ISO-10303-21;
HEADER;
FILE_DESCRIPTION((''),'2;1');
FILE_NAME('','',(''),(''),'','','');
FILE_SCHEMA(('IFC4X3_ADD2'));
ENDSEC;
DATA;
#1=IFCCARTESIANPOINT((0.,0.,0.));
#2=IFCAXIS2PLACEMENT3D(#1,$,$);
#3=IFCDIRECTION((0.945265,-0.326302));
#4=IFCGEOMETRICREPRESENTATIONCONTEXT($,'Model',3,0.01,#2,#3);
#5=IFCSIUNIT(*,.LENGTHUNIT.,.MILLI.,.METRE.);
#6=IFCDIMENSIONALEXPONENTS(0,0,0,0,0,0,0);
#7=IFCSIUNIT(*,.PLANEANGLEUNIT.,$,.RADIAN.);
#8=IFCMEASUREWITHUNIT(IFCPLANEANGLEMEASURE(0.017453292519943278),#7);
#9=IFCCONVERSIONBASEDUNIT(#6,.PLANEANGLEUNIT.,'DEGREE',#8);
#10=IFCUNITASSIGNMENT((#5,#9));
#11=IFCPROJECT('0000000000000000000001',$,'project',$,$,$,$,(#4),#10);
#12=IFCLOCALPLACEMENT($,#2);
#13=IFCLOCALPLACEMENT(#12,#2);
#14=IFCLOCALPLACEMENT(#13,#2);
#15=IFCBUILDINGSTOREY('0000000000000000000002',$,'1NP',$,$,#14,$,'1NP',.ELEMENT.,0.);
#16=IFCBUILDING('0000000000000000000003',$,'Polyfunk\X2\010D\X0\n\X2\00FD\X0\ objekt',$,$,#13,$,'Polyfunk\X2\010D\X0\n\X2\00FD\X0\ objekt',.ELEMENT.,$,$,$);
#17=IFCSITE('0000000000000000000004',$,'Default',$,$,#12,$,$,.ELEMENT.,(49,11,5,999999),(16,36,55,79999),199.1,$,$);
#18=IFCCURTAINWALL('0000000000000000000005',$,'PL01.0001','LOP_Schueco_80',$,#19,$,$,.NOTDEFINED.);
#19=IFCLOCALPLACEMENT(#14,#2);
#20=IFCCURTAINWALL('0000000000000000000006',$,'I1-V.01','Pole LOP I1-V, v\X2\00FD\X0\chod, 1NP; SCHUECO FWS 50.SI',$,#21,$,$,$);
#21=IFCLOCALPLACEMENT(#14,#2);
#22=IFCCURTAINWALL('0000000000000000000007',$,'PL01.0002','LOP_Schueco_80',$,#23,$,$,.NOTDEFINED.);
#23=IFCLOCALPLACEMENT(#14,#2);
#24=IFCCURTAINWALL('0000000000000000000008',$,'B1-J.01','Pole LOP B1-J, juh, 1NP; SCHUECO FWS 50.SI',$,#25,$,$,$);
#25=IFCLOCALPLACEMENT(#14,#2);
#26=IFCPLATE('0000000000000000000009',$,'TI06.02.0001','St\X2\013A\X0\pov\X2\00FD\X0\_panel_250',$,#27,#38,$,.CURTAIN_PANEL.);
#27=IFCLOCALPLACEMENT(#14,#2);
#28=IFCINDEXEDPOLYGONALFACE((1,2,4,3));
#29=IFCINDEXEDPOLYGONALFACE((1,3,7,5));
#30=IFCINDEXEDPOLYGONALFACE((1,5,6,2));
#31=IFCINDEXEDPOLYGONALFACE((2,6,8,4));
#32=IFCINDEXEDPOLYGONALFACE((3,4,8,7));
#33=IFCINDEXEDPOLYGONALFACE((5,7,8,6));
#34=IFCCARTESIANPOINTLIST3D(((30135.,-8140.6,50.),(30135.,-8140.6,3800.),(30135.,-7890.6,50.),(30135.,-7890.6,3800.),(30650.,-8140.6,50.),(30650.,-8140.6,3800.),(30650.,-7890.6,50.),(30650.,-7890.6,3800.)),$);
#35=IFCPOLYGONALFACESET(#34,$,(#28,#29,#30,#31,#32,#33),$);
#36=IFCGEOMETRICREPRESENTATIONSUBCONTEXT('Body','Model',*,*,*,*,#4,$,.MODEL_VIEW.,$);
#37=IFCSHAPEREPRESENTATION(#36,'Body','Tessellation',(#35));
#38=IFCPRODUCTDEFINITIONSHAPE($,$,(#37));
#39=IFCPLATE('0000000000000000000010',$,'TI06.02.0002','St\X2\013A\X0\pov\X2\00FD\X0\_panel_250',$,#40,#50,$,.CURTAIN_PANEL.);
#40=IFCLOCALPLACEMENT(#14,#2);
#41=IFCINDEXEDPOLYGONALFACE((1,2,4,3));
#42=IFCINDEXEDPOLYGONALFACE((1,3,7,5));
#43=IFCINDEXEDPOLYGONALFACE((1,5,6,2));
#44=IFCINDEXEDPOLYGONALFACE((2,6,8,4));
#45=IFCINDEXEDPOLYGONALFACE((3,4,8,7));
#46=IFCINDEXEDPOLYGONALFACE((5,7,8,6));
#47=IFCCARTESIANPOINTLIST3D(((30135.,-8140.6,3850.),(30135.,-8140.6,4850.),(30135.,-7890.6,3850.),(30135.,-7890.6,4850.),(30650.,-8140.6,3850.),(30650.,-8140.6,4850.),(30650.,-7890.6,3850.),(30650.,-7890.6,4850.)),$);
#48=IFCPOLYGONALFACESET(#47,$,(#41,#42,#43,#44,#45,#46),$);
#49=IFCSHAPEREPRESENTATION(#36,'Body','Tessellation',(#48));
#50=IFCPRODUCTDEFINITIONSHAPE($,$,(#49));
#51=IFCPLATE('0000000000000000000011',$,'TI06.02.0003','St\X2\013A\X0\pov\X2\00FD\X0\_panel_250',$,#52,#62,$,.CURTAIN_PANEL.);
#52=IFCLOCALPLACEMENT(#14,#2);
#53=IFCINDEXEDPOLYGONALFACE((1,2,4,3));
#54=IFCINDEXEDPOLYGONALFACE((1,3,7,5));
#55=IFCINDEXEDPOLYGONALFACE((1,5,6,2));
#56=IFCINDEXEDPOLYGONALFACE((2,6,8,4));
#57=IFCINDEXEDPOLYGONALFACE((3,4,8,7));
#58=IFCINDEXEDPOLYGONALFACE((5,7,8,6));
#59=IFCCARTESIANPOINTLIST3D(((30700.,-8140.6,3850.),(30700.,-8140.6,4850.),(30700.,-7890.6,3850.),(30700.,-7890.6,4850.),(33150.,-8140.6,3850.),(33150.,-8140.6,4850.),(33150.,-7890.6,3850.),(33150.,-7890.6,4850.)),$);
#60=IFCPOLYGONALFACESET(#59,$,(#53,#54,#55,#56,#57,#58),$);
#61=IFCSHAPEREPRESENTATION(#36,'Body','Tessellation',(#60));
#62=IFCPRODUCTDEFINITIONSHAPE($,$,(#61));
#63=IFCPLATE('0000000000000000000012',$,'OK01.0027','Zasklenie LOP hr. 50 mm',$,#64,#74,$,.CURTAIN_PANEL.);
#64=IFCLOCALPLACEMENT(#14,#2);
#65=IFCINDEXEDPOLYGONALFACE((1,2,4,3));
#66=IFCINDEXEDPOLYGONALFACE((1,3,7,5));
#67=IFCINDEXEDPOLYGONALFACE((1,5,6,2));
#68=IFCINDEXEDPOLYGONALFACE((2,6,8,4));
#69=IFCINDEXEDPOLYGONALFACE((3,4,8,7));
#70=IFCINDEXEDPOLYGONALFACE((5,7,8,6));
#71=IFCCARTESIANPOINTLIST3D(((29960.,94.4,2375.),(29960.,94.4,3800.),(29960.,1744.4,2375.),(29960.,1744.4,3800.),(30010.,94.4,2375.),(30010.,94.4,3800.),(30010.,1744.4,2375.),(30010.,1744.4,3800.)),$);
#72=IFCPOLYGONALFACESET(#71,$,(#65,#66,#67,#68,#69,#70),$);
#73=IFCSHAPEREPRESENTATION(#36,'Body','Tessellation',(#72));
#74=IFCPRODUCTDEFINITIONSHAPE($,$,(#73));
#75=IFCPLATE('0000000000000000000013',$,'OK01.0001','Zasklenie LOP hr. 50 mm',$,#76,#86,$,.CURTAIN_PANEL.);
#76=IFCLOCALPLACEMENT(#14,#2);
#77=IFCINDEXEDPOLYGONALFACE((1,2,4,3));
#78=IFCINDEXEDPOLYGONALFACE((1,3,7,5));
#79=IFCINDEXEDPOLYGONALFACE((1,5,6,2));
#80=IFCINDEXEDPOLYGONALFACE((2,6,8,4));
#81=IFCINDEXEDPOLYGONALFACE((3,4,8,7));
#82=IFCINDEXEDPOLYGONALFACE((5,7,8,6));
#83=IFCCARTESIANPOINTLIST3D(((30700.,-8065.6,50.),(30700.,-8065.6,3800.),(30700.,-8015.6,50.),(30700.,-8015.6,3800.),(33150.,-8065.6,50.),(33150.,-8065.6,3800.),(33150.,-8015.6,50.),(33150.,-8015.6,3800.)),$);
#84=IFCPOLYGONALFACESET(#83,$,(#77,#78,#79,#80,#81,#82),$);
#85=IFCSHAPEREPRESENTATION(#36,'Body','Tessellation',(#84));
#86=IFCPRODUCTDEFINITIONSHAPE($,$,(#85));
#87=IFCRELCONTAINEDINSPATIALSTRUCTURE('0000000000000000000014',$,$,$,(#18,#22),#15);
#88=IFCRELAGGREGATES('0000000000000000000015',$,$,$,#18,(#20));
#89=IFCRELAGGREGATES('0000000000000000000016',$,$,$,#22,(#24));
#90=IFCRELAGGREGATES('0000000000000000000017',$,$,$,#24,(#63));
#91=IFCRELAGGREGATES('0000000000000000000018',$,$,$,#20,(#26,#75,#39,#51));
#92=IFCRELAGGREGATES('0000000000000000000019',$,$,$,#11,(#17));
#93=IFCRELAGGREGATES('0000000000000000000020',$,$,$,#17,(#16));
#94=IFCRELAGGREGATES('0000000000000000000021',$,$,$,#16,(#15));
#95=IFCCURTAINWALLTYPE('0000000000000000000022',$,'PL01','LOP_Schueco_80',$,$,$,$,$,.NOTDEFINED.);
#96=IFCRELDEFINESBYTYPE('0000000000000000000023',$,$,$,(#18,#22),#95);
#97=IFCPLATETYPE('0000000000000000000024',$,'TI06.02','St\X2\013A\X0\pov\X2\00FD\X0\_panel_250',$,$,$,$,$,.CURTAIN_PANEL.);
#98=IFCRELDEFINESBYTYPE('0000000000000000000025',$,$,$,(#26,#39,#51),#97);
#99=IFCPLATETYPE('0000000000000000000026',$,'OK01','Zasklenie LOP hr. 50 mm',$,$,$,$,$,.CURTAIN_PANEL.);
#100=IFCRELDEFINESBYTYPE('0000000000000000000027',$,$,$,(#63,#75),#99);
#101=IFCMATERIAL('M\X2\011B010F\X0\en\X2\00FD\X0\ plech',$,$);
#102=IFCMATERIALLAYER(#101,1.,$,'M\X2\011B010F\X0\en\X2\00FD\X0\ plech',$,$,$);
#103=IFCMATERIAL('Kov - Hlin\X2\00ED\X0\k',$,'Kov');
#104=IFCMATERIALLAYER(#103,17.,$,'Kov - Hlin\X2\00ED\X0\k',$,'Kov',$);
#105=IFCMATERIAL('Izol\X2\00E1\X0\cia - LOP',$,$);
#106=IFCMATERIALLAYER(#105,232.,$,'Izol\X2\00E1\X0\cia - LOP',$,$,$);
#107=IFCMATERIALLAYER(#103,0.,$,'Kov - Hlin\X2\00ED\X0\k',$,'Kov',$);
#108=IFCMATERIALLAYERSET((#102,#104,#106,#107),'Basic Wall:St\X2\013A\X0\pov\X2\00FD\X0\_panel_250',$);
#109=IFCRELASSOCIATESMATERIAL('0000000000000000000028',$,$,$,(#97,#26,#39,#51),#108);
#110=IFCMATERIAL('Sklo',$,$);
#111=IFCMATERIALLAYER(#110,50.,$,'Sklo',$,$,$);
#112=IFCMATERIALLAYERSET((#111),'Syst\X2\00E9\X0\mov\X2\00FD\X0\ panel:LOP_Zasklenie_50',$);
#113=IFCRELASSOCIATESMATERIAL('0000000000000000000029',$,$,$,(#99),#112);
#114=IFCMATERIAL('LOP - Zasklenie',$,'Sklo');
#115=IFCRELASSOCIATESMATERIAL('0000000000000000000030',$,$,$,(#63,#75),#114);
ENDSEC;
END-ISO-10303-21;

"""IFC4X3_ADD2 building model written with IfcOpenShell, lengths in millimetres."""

from ifc_helpers import new_model, entity, si_unit, converted_unit, direction, frame, frame_2d, origin, origin_2d_with_axis, place, context, subcontext, project, spatial, rectangle, extrude, source, transform, mapped, material, layer, layer_set, layer_usage, type_object, type_shapes, element, aggregate, save


model = new_model("IFC4X3_ADD2")

# Units and contexts
model_context = context("Model", 3, precision=0.01, world=origin(), true_north=direction((0.945265, -0.326302)))
body_context = subcontext(model_context, "Body", "Model", "MODEL_VIEW")
ifc_project = project(units=[si_unit("LENGTHUNIT", "METRE", prefix="MILLI"), converted_unit("PLANEANGLEUNIT", "DEGREE", entity("IfcPlaneAngleMeasure", 0.017453292519943278), si_unit("PLANEANGLEUNIT", "RADIAN"), dimensions=[0, 0, 0, 0, 0, 0, 0])], contexts=[model_context])

# Site, building, storey
site_placement = place(None, origin())
site = spatial("IfcSite", under=ifc_project, at=site_placement, Name="Default", CompositionType="ELEMENT", RefLatitude=(49, 11, 5, 999999), RefLongitude=(16, 36, 55, 79999), RefElevation=199.1)
building_placement = place(site_placement, origin())
building = spatial("IfcBuilding", under=site, at=building_placement, Name="Polyfunkčný objekt", LongName="Polyfunkčný objekt", CompositionType="ELEMENT")
storey_placement = place(building_placement, origin())
storey = spatial("IfcBuildingStorey", under=building, at=storey_placement, Name="1NP", LongName="1NP", CompositionType="ELEMENT", Elevation=0.0)

# Curtain walls
curtain_wall_type = type_object("IfcCurtainWallType", Name="PL01", Description="LOP_Schueco_80", PredefinedType="NOTDEFINED")
curtain_wall_1_placement = place(storey_placement, origin())
curtain_wall_1 = element("IfcCurtainWall", 1, at=curtain_wall_1_placement, inside=storey, type_object=curtain_wall_type, Name="PL01.0001", Description="LOP_Schueco_80", PredefinedType="NOTDEFINED")
curtain_wall_2 = element("IfcCurtainWall", 2, Name="I1-V.01", Description="Pole LOP I1-V, východ, 1NP; SCHUECO FWS 50.SI")
aggregate(curtain_wall_1, [curtain_wall_2])

# Curtain walls
curtain_wall_3_placement = place(storey_placement, origin())
curtain_wall_3 = element("IfcCurtainWall", 3, at=curtain_wall_3_placement, inside=storey, type_object=curtain_wall_type, Name="PL01.0002", Description="LOP_Schueco_80", PredefinedType="NOTDEFINED")
curtain_wall_4 = element("IfcCurtainWall", 4, Name="B1-J.01", Description="Pole LOP B1-J, juh, 1NP; SCHUECO FWS 50.SI")
aggregate(curtain_wall_3, [curtain_wall_4])

# Plates
ifc_material_1 = material(Name="Měďený plech")
ifc_layer_1 = layer(ifc_material_1, 1.0, Name="Měďený plech")
ifc_material_2 = material(Name="Kov - Hliník", Category="Kov")
ifc_layer_2 = layer(ifc_material_2, 17.0, Name="Kov - Hliník", Category="Kov")
ifc_material_3 = material(Name="Izolácia - LOP")
ifc_layer_3 = layer(ifc_material_3, 232.0, Name="Izolácia - LOP")
ifc_layer_4 = layer(ifc_material_2, 0.0, Name="Kov - Hliník", Category="Kov")
ifc_layer_set_1 = layer_set([ifc_layer_1, ifc_layer_2, ifc_layer_3, ifc_layer_4], Name="Basic Wall:Stĺpový_panel_250")
ifc_layer_usage_1 = layer_usage(ifc_layer_set_1, "AXIS2", "POSITIVE", -125.0)
plate_type_1 = type_object("IfcPlateType", Name="TI06.02", Description="Stĺpový_panel_250", PredefinedType="CURTAIN_PANEL", material=ifc_layer_set_1)
plate_1_placement = place(storey_placement, frame((30135.0, -8015.6, 50.0)))
plate_1 = element("IfcPlate", 5, at=plate_1_placement, type_object=plate_type_1, material=ifc_layer_usage_1, Name="TI06.02.0001", Description="Stĺpový_panel_250", PredefinedType="CURTAIN_PANEL", context=body_context, shape_type="SweptSolid", body=[
    extrude(rectangle(XDim=250.0, YDim=515.0, at=frame_2d((0.0, 0.0), x_axis=(1.0, 0.0))), frame((257.5, 0.0, 0.0), z_axis=(0.0, 0.0, 1.0), x_axis=(0.0, 1.0, 0.0)), (0.0, 0.0, 1.0), 3750.0),
])
ifc_layer_usage_2 = layer_usage(ifc_layer_set_1, "AXIS2", "POSITIVE", -125.0)
plate_2_placement = place(storey_placement, frame((30135.0, -8015.6, 3850.0)))
plate_2 = element("IfcPlate", 6, at=plate_2_placement, type_object=plate_type_1, material=ifc_layer_usage_2, Name="TI06.02.0002", Description="Stĺpový_panel_250", PredefinedType="CURTAIN_PANEL", context=body_context, shape_type="SweptSolid", body=[
    extrude(rectangle(XDim=250.0, YDim=515.0, at=frame_2d((0.0, 0.0), x_axis=(1.0, 0.0))), frame((257.5, 0.0, 0.0), z_axis=(0.0, 0.0, 1.0), x_axis=(0.0, 1.0, 0.0)), (0.0, 0.0, 1.0), 1000.0),
])
ifc_layer_usage_3 = layer_usage(ifc_layer_set_1, "AXIS2", "POSITIVE", -125.0)
plate_3_placement = place(storey_placement, frame((30700.0, -8015.6, 3850.0)))
plate_3 = element("IfcPlate", 7, at=plate_3_placement, type_object=plate_type_1, material=ifc_layer_usage_3, Name="TI06.02.0003", Description="Stĺpový_panel_250", PredefinedType="CURTAIN_PANEL", context=body_context, shape_type="SweptSolid", body=[
    extrude(rectangle(XDim=250.0, YDim=2450.0, at=frame_2d((0.0, 0.0), x_axis=(1.0, 0.0))), frame((1225.0, 0.0, 0.0), z_axis=(0.0, 0.0, 1.0), x_axis=(0.0, 1.0, 0.0)), (0.0, 0.0, 1.0), 1000.0),
])
ifc_material_4 = material(Name="LOP - Zasklenie", Category="Sklo")
ifc_material_5 = material(Name="Sklo")
ifc_layer_5 = layer(ifc_material_5, 50.0, Name="Sklo")
ifc_layer_set_2 = layer_set([ifc_layer_5], Name="Systémový panel:LOP_Zasklenie_50")
plate_type_2 = type_object("IfcPlateType", Name="OK01", Description="Zasklenie LOP hr. 50 mm", PredefinedType="CURTAIN_PANEL", material=ifc_layer_set_2)
shared_shape_1 = source(origin(), body_context, "Body", "SweptSolid", [
    extrude(rectangle(XDim=50.0, YDim=1650.0, at=origin_2d_with_axis()), frame((0.0, -25.0, 0.0), z_axis=(0.0, 0.0, 1.0), x_axis=(0.0, 1.0, 0.0)), (0.0, 0.0, 1.0), 1425.0),
])
plate_4_placement = place(curtain_wall_3_placement, frame((30010.0, 919.4, 2375.0), z_axis=(0.0, 0.0, 1.0), x_axis=(0.0, -1.0, 0.0)))
plate_4 = element("IfcPlate", 8, at=plate_4_placement, type_object=plate_type_2, material=ifc_material_4, Name="OK01.0027", Description="Zasklenie LOP hr. 50 mm", PredefinedType="CURTAIN_PANEL", context=body_context, shape_type="MappedRepresentation", body=[
    mapped(shared_shape_1, transform((0.0, 0.0, 0.0), scale=1.0)),
])
aggregate(curtain_wall_4, [plate_4])
shared_shape_2 = source(origin(), body_context, "Body", "SweptSolid", [
    extrude(rectangle(XDim=3750.0, YDim=2450.0, at=frame_2d((-331.2, 0.0), x_axis=(1.0, 0.0))), frame((0.0, -50.0, 2206.2), z_axis=(0.0, 1.0, 0.0), x_axis=(0.0, 0.0, 1.0)), (0.0, 0.0, 1.0), 50.0),
])
type_shapes(plate_type_2, [shared_shape_1, shared_shape_2])
plate_5_placement = place(curtain_wall_1_placement, frame((31925.0, -8015.6, 50.0)))
plate_5 = element("IfcPlate", 9, at=plate_5_placement, type_object=plate_type_2, material=ifc_material_4, Name="OK01.0001", Description="Zasklenie LOP hr. 50 mm", PredefinedType="CURTAIN_PANEL", context=body_context, shape_type="MappedRepresentation", body=[
    mapped(shared_shape_2, transform((0.0, 0.0, 0.0), scale=1.0)),
])
aggregate(curtain_wall_2, [plate_1, plate_5, plate_2, plate_3])

save(model, "model.ifc")
